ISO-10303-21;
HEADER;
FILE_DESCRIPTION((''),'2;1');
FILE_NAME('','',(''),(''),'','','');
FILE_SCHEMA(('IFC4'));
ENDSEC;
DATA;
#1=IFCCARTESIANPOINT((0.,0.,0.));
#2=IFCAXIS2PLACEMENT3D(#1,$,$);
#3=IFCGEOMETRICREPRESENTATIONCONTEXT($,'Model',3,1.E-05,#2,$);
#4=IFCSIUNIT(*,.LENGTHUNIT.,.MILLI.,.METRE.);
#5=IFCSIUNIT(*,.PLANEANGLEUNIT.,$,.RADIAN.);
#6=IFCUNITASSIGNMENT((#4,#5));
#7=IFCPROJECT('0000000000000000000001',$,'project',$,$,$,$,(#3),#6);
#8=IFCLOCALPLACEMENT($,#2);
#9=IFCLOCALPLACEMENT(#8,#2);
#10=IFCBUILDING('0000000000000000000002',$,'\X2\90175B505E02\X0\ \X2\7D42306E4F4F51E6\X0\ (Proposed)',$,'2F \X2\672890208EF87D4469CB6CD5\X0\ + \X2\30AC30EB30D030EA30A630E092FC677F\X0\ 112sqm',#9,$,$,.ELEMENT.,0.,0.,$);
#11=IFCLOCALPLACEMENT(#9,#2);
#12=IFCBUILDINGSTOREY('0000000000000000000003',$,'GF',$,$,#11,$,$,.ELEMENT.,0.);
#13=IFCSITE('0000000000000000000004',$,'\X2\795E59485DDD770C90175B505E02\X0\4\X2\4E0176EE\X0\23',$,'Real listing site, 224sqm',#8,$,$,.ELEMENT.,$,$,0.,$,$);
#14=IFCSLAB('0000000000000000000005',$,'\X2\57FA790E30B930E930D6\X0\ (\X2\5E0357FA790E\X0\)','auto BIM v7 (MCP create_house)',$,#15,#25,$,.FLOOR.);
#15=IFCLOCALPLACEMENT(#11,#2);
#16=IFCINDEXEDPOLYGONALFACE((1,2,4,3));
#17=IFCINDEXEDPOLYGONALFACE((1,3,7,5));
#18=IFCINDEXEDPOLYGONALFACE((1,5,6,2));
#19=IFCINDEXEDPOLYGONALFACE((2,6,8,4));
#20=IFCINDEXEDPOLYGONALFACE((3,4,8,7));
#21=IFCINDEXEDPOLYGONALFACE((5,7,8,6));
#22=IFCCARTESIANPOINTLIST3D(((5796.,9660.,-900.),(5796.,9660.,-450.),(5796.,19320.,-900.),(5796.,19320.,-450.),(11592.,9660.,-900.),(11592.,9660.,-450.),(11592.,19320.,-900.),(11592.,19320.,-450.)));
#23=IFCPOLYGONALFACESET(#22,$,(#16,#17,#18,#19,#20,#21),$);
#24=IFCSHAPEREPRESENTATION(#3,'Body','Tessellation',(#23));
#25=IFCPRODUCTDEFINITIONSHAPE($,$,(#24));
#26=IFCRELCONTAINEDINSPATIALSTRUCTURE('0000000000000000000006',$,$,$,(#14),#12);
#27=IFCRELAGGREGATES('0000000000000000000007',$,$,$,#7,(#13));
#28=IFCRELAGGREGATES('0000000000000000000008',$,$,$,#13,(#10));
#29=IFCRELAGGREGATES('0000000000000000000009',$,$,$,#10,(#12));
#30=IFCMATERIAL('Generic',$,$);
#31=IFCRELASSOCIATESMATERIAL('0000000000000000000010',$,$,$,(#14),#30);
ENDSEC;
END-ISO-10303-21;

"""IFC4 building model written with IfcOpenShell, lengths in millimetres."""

from ifc_helpers import new_model, si_unit, frame, frame_2d, origin, place, context, project, spatial, rectangle, extrude, material, element, save


model = new_model("IFC4")

# Units and contexts
model_context = context("Model", 3, precision=1e-05, world=origin())
ifc_project = project(units=[si_unit("LENGTHUNIT", "METRE", prefix="MILLI"), si_unit("PLANEANGLEUNIT", "RADIAN")], contexts=[model_context])

# Site, building, storey
site_placement = place(None, origin())
site = spatial("IfcSite", under=ifc_project, at=site_placement, Name="神奈川県逗子市4丁目23", ObjectType="Real listing site, 224sqm", CompositionType="ELEMENT", RefElevation=0.0)
building_placement = place(site_placement, origin())
building = spatial("IfcBuilding", under=site, at=building_placement, Name="逗子市 終の住処 (Proposed)", ObjectType="2F 木造軸組構法 + ガルバリウム鋼板 112sqm", CompositionType="ELEMENT", ElevationOfRefHeight=0.0, ElevationOfTerrain=0.0)
storey_placement = place(building_placement, origin())
storey = spatial("IfcBuildingStorey", under=building, at=storey_placement, Name="GF", CompositionType="ELEMENT", Elevation=0.0)

# Slab
ifc_material = material(Name="Generic")
slab_1_placement = place(storey_placement, frame((2898.0, 4830.0, -450.0)))
element("IfcSlab", 1, at=slab_1_placement, inside=storey, material=ifc_material, Name="基礎スラブ (布基礎)", Description="auto BIM v7 (MCP create_house)", PredefinedType="FLOOR", context=model_context, shape_type="SweptSolid", body=[
    extrude(rectangle(XDim=5796.0, YDim=9660.0, at=frame_2d((2898.0, 4830.0))), frame((2898.0, 4830.0, -450.0)), (0.0, 0.0, 1.0), 450.0),
])

save(model, "model.ifc")
